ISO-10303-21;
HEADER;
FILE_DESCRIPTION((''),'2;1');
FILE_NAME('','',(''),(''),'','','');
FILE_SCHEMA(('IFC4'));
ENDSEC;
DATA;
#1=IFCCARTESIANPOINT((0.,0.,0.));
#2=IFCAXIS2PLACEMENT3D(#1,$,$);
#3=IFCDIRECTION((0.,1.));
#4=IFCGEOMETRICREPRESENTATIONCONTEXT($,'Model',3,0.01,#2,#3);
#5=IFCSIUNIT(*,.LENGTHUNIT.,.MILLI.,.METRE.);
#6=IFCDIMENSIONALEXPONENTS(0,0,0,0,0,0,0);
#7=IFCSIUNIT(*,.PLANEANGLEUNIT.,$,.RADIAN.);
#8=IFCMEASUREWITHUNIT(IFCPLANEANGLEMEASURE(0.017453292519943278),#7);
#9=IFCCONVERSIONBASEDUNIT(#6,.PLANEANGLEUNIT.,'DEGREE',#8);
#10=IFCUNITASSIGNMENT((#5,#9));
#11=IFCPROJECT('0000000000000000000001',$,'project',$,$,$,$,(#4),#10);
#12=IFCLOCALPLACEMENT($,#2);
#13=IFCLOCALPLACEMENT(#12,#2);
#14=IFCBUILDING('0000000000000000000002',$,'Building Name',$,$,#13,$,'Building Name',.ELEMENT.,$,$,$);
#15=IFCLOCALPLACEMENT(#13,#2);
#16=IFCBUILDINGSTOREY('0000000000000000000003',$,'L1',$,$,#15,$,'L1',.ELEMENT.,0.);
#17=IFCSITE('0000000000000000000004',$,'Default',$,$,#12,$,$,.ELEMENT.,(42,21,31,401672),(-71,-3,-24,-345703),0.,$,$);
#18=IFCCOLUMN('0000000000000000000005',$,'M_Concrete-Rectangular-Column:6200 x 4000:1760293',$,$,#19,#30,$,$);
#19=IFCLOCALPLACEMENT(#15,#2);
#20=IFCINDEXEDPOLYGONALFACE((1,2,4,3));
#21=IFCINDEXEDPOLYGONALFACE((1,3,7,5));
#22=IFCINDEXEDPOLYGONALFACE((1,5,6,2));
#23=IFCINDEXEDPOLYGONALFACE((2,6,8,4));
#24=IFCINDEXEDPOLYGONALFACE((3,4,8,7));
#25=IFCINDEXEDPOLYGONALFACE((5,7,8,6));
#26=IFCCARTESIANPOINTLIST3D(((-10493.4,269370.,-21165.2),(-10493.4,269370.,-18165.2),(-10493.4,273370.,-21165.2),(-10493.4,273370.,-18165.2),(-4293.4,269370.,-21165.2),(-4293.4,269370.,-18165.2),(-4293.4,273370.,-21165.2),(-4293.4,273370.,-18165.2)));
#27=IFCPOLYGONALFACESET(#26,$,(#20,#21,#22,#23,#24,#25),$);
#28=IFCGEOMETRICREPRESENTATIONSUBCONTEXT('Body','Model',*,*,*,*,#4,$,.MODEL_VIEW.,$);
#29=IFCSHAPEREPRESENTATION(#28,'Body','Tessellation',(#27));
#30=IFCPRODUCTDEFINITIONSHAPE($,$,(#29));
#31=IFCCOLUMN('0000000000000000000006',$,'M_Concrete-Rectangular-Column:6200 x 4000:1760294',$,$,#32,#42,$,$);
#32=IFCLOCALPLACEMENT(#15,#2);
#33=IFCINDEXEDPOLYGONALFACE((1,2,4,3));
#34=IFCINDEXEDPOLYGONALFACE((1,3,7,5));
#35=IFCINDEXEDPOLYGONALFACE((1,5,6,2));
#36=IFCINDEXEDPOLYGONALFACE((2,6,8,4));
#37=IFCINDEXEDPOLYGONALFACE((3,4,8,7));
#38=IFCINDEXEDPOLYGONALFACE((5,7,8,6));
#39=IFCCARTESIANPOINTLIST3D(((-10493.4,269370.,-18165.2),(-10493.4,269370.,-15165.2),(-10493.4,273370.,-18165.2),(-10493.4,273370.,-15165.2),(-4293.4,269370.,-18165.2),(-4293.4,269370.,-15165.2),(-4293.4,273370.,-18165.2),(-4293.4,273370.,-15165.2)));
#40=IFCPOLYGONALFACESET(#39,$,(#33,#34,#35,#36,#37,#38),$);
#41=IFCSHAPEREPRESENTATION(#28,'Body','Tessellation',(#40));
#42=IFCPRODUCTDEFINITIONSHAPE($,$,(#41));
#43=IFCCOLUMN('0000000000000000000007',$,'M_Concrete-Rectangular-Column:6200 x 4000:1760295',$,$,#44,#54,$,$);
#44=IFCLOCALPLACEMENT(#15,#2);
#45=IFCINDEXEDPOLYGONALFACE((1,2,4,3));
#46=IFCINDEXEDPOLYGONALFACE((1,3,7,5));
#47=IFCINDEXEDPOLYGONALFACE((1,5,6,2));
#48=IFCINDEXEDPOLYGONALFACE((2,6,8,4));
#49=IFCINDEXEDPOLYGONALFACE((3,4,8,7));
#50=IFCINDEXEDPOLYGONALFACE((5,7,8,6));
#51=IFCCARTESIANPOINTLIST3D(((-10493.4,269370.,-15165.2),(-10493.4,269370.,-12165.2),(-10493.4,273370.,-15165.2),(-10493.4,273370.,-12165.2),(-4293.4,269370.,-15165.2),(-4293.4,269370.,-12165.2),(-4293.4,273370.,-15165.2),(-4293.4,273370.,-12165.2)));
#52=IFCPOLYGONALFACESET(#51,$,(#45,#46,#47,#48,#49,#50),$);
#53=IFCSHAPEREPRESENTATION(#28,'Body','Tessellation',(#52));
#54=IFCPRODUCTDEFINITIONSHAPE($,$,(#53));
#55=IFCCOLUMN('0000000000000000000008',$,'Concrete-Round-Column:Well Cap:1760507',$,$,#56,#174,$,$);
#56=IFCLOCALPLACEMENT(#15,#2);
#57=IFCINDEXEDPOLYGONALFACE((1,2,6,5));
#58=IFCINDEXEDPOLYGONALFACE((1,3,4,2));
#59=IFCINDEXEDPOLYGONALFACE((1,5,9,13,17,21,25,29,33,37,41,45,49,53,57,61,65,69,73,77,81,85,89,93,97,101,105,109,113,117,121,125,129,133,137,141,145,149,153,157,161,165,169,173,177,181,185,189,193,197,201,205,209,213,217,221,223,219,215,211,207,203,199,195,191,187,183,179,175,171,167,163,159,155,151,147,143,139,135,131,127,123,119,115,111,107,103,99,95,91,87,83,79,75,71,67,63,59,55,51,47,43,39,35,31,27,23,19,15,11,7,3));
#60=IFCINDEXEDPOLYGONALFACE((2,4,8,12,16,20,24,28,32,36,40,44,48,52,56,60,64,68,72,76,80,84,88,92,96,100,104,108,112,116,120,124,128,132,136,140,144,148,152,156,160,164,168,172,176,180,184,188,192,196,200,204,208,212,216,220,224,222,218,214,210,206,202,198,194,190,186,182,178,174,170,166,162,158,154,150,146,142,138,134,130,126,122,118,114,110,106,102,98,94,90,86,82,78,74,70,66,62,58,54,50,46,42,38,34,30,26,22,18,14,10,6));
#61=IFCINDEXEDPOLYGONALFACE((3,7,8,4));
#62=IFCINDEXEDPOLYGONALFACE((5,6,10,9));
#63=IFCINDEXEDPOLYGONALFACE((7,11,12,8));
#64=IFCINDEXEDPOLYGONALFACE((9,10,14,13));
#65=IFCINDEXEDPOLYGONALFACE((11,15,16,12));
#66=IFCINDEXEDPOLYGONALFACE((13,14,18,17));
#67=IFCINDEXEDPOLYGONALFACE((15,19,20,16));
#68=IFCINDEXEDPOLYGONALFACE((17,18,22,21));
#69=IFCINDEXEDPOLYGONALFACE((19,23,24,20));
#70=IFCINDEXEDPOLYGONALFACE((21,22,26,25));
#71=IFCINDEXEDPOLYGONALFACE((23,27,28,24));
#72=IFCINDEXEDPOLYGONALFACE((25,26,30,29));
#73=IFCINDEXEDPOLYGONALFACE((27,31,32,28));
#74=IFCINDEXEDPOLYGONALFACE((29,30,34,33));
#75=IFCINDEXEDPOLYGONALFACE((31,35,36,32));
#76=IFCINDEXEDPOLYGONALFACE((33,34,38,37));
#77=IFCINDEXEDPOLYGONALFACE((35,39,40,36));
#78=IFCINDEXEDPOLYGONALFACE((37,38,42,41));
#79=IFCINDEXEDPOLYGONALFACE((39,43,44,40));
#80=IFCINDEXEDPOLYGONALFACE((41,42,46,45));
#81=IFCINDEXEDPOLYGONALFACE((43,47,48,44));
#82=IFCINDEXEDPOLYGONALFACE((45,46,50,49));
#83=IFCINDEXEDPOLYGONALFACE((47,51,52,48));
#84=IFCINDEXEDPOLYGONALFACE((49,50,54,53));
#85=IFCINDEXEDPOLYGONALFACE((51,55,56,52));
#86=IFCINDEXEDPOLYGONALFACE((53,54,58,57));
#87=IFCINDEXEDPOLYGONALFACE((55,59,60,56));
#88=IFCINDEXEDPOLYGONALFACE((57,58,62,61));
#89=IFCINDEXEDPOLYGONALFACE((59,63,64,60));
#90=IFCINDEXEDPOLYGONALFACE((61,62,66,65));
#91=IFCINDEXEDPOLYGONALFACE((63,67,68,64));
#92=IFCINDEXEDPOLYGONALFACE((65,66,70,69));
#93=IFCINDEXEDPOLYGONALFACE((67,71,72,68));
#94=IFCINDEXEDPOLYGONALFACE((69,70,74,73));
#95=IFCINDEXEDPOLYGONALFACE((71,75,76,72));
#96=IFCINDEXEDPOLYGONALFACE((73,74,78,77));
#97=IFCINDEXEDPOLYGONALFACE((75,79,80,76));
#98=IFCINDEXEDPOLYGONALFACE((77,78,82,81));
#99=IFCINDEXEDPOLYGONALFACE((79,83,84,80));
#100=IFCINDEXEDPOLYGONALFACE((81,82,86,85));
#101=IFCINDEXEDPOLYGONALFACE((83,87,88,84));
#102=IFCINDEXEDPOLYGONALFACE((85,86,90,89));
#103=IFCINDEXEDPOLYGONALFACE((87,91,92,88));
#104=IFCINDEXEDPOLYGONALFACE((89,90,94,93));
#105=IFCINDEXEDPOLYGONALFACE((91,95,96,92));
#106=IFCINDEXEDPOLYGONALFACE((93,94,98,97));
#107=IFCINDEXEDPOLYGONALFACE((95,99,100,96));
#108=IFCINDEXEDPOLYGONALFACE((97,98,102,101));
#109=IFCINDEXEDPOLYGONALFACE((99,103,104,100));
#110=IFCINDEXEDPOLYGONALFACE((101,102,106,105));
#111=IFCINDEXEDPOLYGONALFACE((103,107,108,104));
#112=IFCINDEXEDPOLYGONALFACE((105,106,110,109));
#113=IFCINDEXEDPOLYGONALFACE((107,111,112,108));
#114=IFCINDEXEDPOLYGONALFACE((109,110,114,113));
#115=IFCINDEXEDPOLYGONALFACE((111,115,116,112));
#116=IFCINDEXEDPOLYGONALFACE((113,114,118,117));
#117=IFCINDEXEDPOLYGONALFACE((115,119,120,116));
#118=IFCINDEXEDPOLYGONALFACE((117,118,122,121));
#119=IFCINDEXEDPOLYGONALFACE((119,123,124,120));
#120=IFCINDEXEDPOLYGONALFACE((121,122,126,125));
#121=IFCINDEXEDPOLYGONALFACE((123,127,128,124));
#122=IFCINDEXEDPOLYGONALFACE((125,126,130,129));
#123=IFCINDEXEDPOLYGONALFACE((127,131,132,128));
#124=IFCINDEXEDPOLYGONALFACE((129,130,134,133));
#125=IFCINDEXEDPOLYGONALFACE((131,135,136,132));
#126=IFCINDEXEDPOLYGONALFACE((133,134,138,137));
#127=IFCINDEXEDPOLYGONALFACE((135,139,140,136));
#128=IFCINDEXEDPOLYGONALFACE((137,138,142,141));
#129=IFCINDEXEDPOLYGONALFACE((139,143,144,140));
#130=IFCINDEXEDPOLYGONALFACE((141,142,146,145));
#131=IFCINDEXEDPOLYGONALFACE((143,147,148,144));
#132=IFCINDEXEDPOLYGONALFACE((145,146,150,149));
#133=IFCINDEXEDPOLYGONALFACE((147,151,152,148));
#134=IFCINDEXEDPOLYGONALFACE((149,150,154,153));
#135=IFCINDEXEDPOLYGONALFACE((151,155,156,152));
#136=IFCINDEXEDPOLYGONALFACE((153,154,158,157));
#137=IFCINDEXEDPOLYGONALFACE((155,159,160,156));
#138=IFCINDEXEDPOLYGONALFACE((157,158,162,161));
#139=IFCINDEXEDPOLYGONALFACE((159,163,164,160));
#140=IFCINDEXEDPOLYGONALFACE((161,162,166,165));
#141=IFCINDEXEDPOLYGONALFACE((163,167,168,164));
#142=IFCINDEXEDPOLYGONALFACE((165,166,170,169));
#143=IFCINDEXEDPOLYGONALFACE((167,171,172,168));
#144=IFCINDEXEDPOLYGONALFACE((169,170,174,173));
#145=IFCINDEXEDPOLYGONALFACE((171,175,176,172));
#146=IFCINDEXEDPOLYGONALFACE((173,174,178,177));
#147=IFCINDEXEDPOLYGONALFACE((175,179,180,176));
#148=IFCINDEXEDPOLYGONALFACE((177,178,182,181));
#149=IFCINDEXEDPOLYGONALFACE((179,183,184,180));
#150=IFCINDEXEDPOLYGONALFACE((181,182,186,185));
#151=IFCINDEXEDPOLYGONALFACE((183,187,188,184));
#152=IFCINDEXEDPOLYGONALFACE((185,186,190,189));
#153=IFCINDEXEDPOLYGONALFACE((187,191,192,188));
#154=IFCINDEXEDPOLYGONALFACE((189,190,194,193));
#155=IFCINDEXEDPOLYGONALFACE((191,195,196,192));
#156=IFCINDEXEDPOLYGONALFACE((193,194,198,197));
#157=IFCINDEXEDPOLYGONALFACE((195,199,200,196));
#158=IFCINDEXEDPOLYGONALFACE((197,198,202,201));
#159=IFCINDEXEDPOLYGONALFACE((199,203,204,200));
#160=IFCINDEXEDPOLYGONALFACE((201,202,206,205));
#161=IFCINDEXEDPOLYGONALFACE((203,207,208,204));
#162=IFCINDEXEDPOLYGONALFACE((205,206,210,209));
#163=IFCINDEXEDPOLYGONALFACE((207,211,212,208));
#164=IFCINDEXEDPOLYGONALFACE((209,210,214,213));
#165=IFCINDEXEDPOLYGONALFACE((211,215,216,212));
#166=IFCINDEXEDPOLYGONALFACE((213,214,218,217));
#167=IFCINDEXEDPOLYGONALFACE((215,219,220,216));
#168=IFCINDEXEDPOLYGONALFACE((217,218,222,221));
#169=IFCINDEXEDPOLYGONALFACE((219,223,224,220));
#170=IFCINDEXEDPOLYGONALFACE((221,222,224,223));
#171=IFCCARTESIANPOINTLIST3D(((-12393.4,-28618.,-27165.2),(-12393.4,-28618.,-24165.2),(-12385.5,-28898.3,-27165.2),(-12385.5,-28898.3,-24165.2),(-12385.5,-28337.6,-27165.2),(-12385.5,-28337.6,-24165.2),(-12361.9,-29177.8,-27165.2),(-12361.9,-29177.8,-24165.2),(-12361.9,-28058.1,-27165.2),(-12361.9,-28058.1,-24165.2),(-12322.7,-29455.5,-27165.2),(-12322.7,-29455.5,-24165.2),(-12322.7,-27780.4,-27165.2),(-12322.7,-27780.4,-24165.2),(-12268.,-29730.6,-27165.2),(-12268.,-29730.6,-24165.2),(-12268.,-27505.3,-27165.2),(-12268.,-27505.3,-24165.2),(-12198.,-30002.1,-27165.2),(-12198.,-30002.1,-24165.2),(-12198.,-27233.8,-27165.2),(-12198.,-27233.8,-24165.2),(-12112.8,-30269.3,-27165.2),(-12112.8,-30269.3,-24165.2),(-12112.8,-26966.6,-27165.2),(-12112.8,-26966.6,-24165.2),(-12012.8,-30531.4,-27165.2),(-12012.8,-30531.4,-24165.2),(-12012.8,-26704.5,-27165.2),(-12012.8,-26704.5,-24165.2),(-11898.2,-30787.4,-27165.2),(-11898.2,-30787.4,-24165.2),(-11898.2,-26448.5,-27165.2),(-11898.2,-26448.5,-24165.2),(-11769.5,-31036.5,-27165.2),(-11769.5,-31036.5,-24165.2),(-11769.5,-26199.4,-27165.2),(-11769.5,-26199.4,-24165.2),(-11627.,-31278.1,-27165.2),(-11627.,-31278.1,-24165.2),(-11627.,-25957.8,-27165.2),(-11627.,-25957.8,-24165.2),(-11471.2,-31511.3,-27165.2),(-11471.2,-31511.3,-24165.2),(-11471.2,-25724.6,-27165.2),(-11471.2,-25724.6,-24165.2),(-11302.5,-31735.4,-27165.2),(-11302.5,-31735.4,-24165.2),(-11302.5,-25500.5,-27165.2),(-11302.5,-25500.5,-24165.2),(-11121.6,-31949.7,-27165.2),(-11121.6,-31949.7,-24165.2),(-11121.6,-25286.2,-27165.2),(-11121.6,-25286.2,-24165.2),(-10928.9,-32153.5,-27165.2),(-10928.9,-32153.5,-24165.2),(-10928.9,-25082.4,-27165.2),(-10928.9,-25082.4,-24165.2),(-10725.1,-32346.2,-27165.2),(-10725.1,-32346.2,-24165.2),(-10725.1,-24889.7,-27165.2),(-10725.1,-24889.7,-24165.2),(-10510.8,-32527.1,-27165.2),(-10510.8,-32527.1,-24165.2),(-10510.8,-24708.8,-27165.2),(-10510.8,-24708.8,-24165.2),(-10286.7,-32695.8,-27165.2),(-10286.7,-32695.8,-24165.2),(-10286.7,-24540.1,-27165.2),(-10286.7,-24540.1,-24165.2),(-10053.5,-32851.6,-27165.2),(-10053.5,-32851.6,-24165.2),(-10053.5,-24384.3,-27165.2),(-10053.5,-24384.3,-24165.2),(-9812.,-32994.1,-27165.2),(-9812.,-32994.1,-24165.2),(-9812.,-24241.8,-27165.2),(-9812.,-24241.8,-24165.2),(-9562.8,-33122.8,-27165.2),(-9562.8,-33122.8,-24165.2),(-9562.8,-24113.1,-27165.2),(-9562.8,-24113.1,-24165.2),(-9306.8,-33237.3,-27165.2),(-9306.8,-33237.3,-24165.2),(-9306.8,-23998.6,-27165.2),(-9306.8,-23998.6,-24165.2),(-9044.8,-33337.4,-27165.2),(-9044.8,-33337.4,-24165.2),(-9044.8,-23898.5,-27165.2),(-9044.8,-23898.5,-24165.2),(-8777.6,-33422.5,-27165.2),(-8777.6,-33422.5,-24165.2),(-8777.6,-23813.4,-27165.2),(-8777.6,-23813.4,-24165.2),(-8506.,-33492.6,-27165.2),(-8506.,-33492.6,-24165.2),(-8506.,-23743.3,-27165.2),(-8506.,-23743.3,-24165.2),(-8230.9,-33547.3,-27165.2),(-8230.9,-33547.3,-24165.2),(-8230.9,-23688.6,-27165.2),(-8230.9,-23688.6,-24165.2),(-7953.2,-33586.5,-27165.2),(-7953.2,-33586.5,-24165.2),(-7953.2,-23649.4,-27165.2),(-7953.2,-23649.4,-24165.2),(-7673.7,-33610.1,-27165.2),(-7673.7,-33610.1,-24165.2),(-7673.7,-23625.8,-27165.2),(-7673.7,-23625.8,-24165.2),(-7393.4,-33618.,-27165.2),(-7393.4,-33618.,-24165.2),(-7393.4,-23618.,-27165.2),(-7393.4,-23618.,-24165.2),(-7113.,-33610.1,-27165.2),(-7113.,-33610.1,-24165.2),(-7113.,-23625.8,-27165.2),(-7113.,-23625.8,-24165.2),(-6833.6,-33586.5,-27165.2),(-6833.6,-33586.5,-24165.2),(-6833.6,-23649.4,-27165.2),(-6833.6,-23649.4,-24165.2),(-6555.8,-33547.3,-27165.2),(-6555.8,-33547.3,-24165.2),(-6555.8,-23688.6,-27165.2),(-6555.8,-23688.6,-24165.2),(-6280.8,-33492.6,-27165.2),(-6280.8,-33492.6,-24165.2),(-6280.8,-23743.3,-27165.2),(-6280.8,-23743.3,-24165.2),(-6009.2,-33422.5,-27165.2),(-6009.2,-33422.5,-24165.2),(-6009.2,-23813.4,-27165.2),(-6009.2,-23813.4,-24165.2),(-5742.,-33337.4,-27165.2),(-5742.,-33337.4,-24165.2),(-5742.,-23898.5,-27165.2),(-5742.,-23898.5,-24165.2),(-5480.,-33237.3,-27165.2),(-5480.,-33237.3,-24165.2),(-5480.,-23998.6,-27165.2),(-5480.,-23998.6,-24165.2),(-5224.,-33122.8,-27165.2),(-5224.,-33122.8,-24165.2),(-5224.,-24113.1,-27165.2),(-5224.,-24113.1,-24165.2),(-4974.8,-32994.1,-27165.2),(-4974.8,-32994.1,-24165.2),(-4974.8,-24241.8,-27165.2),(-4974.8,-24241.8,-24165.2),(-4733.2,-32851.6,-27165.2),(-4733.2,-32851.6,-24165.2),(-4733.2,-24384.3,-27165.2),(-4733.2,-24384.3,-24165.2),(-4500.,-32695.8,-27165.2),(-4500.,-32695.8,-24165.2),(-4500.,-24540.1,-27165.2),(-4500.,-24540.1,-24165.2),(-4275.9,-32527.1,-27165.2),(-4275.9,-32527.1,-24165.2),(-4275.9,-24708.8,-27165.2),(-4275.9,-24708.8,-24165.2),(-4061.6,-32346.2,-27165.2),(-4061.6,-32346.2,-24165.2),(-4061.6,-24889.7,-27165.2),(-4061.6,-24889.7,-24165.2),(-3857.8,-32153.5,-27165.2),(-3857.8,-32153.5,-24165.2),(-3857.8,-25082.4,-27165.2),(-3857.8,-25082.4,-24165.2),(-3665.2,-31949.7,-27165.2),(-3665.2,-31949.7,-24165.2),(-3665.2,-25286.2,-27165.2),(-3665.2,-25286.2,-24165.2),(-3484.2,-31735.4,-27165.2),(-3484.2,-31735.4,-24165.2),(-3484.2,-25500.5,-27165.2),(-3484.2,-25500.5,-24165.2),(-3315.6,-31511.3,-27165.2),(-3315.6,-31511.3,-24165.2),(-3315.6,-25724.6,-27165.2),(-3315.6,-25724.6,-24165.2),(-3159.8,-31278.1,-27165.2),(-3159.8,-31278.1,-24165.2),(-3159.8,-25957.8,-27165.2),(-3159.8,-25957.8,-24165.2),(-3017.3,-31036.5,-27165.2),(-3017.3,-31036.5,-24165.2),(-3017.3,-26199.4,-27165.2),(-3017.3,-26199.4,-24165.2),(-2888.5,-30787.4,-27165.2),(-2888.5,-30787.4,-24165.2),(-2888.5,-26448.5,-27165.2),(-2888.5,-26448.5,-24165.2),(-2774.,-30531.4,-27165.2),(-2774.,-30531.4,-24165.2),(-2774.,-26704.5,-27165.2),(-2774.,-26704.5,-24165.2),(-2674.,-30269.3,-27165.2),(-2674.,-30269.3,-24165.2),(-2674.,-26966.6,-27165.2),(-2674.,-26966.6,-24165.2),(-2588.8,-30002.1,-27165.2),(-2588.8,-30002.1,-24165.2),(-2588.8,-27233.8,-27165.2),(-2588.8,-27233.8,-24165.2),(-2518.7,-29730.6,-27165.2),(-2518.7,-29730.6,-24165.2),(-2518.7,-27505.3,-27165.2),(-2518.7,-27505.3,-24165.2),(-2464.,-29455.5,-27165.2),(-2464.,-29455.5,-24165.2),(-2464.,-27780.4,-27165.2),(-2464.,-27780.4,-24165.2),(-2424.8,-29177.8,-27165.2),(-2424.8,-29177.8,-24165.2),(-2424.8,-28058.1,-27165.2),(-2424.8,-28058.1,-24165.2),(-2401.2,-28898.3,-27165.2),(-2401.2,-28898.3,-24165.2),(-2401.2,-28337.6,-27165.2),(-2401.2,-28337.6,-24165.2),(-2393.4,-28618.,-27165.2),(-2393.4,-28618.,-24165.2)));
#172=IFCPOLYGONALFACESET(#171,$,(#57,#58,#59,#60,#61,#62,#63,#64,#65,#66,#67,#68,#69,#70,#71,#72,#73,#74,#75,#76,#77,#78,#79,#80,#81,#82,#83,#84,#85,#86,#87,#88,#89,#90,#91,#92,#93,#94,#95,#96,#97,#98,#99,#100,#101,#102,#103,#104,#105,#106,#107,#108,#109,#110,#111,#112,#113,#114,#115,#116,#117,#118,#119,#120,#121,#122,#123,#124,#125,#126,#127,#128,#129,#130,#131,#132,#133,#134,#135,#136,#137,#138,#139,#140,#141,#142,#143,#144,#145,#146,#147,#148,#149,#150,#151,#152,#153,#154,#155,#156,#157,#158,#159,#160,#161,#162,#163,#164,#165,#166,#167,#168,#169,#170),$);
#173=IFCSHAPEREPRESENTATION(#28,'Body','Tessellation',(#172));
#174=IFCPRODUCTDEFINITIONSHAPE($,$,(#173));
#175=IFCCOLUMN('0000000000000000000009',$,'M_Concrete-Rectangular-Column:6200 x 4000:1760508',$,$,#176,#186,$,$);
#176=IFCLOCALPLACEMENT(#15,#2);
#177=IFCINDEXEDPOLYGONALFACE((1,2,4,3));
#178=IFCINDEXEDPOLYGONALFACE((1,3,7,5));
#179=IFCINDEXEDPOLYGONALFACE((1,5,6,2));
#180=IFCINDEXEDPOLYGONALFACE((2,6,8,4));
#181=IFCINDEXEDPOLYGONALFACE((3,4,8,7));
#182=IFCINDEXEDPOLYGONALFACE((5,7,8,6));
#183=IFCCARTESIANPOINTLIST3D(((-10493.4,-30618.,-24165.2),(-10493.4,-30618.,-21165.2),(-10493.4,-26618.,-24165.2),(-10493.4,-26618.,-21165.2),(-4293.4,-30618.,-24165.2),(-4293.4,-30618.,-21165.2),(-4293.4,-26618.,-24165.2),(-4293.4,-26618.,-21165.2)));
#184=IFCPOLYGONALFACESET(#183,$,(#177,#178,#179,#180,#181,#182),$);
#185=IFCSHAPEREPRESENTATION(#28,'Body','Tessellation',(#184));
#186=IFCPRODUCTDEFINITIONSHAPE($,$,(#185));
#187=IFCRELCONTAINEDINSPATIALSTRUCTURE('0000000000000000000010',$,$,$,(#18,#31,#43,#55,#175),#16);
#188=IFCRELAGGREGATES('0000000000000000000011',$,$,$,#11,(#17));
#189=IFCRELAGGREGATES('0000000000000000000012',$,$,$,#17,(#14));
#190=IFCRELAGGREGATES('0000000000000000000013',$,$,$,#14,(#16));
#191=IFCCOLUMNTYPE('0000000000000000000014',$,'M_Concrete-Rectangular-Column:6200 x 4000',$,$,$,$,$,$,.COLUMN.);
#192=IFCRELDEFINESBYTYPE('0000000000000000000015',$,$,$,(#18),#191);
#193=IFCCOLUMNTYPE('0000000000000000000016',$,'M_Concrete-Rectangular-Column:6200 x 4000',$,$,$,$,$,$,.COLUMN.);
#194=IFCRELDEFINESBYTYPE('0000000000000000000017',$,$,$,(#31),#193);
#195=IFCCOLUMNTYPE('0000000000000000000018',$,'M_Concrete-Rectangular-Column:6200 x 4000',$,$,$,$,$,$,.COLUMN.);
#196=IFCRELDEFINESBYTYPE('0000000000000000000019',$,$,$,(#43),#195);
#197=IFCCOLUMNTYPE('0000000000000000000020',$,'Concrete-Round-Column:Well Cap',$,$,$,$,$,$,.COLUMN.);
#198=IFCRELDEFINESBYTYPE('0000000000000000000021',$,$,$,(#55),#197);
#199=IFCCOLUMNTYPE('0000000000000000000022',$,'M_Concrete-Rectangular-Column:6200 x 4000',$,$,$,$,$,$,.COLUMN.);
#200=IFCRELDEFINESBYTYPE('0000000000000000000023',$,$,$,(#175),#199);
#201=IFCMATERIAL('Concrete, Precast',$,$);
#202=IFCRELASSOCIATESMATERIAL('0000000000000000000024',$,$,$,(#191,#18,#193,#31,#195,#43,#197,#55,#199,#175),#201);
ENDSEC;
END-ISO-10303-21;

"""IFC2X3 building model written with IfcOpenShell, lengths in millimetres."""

from ifc_helpers import new_model, entity, si_unit, converted_unit, direction, frame, frame_2d, origin, place, context, subcontext, project, spatial, rectangle, circle, extrude, source, transform, mapped, material, type_object, type_shapes, element, save


model = new_model("IFC2X3")

# Units and contexts
model_context = context("Model", 3, precision=0.01, world=origin(), true_north=direction((0.0, 1.0)))
body_context = subcontext(model_context, "Body", "Model", "MODEL_VIEW")
ifc_project = project(units=[si_unit("LENGTHUNIT", "METRE", prefix="MILLI"), converted_unit("PLANEANGLEUNIT", "DEGREE", entity("IfcPlaneAngleMeasure", 0.017453292519943278), si_unit("PLANEANGLEUNIT", "RADIAN"), dimensions=[0, 0, 0, 0, 0, 0, 0])], contexts=[model_context])

# Site, building, storey
site_placement = place(None, origin())
site = spatial("IfcSite", under=ifc_project, at=site_placement, Name="Default", CompositionType="ELEMENT", RefLatitude=(42, 21, 31, 401672), RefLongitude=(-71, -3, -24, -345703), RefElevation=0.0)
building_placement = place(site_placement, origin())
building = spatial("IfcBuilding", under=site, at=building_placement, Name="Building Name", LongName="Building Name", CompositionType="ELEMENT")
storey_placement = place(building_placement, origin())
storey = spatial("IfcBuildingStorey", under=building, at=storey_placement, Name="L1", LongName="L1", CompositionType="ELEMENT", Elevation=0.0)

# Columns
ifc_material_1 = material(Name="Concrete, Precast")
column_type_1 = type_object("IfcColumnType", Name="M_Concrete-Rectangular-Column:6200 x 4000", PredefinedType="COLUMN", material=ifc_material_1)
shared_shape_1 = source(origin(), body_context, "Body", "SweptSolid", [
    extrude(rectangle(XDim=4000.0, YDim=6200.0, at=frame_2d((0.0, 0.0), x_axis=(1.0, 0.0))), frame((-7393.4, 271370.0, -21165.2), z_axis=(0.0, 0.0, 1.0), x_axis=(0.0, -1.0, 0.0)), (0.0, 0.0, 1.0), 3000.0),
])
type_shapes(column_type_1, [shared_shape_1])
column_1_placement = place(storey_placement, origin())
element("IfcColumn", 1, at=column_1_placement, inside=storey, type_object=column_type_1, material=ifc_material_1, Name="M_Concrete-Rectangular-Column:6200 x 4000:1760293", context=body_context, shape_type="MappedRepresentation", body=[
    mapped(shared_shape_1, transform((0.0, 0.0, 0.0), scale=1.0)),
])
column_type_2 = type_object("IfcColumnType", Name="M_Concrete-Rectangular-Column:6200 x 4000", PredefinedType="COLUMN", material=ifc_material_1)
shared_shape_2 = source(origin(), body_context, "Body", "SweptSolid", [
    extrude(rectangle(XDim=4000.0, YDim=6200.0, at=frame_2d((0.0, 0.0), x_axis=(1.0, 0.0))), frame((-7393.4, 271370.0, -18165.2), z_axis=(0.0, 0.0, 1.0), x_axis=(0.0, -1.0, 0.0)), (0.0, 0.0, 1.0), 3000.0),
])
type_shapes(column_type_2, [shared_shape_2])
column_2_placement = place(storey_placement, origin())
element("IfcColumn", 2, at=column_2_placement, inside=storey, type_object=column_type_2, material=ifc_material_1, Name="M_Concrete-Rectangular-Column:6200 x 4000:1760294", context=body_context, shape_type="MappedRepresentation", body=[
    mapped(shared_shape_2, transform((0.0, 0.0, 0.0), scale=1.0)),
])
column_type_3 = type_object("IfcColumnType", Name="M_Concrete-Rectangular-Column:6200 x 4000", PredefinedType="COLUMN", material=ifc_material_1)
shared_shape_3 = source(origin(), body_context, "Body", "SweptSolid", [
    extrude(rectangle(XDim=4000.0, YDim=6200.0, at=frame_2d((0.0, 0.0), x_axis=(1.0, 0.0))), frame((-7393.4, 271370.0, -15165.2), z_axis=(0.0, 0.0, 1.0), x_axis=(0.0, -1.0, 0.0)), (0.0, 0.0, 1.0), 3000.0),
])
type_shapes(column_type_3, [shared_shape_3])
column_3_placement = place(storey_placement, origin())
element("IfcColumn", 3, at=column_3_placement, inside=storey, type_object=column_type_3, material=ifc_material_1, Name="M_Concrete-Rectangular-Column:6200 x 4000:1760295", context=body_context, shape_type="MappedRepresentation", body=[
    mapped(shared_shape_3, transform((0.0, 0.0, 0.0), scale=1.0)),
])
column_type_4 = type_object("IfcColumnType", Name="Concrete-Round-Column:Well Cap", PredefinedType="COLUMN", material=ifc_material_1)
shared_shape_4 = source(origin(), body_context, "Body", "SweptSolid", [
    extrude(circle(Radius=5000.0, at=frame_2d((0.0, 0.0), x_axis=(1.0, 0.0))), frame((-7393.4, -28618.0, -27165.2)), (0.0, 0.0, 1.0), 3000.0),
])
type_shapes(column_type_4, [shared_shape_4])
column_4_placement = place(storey_placement, origin())
element("IfcColumn", 4, at=column_4_placement, inside=storey, type_object=column_type_4, material=ifc_material_1, Name="Concrete-Round-Column:Well Cap:1760507", context=body_context, shape_type="MappedRepresentation", body=[
    mapped(shared_shape_4, transform((0.0, 0.0, 0.0), scale=1.0)),
])
column_type_5 = type_object("IfcColumnType", Name="M_Concrete-Rectangular-Column:6200 x 4000", PredefinedType="COLUMN", material=ifc_material_1)
shared_shape_5 = source(origin(), body_context, "Body", "SweptSolid", [
    extrude(rectangle(XDim=4000.0, YDim=6200.0, at=frame_2d((0.0, 0.0), x_axis=(1.0, 0.0))), frame((-7393.4, -28618.0, -24165.2), z_axis=(0.0, 0.0, 1.0), x_axis=(0.0, -1.0, 0.0)), (0.0, 0.0, 1.0), 3000.0),
])
type_shapes(column_type_5, [shared_shape_5])
column_5_placement = place(storey_placement, origin())
element("IfcColumn", 5, at=column_5_placement, inside=storey, type_object=column_type_5, material=ifc_material_1, Name="M_Concrete-Rectangular-Column:6200 x 4000:1760508", context=body_context, shape_type="MappedRepresentation", body=[
    mapped(shared_shape_5, transform((0.0, 0.0, 0.0), scale=1.0)),
])

save(model, "model.ifc")
